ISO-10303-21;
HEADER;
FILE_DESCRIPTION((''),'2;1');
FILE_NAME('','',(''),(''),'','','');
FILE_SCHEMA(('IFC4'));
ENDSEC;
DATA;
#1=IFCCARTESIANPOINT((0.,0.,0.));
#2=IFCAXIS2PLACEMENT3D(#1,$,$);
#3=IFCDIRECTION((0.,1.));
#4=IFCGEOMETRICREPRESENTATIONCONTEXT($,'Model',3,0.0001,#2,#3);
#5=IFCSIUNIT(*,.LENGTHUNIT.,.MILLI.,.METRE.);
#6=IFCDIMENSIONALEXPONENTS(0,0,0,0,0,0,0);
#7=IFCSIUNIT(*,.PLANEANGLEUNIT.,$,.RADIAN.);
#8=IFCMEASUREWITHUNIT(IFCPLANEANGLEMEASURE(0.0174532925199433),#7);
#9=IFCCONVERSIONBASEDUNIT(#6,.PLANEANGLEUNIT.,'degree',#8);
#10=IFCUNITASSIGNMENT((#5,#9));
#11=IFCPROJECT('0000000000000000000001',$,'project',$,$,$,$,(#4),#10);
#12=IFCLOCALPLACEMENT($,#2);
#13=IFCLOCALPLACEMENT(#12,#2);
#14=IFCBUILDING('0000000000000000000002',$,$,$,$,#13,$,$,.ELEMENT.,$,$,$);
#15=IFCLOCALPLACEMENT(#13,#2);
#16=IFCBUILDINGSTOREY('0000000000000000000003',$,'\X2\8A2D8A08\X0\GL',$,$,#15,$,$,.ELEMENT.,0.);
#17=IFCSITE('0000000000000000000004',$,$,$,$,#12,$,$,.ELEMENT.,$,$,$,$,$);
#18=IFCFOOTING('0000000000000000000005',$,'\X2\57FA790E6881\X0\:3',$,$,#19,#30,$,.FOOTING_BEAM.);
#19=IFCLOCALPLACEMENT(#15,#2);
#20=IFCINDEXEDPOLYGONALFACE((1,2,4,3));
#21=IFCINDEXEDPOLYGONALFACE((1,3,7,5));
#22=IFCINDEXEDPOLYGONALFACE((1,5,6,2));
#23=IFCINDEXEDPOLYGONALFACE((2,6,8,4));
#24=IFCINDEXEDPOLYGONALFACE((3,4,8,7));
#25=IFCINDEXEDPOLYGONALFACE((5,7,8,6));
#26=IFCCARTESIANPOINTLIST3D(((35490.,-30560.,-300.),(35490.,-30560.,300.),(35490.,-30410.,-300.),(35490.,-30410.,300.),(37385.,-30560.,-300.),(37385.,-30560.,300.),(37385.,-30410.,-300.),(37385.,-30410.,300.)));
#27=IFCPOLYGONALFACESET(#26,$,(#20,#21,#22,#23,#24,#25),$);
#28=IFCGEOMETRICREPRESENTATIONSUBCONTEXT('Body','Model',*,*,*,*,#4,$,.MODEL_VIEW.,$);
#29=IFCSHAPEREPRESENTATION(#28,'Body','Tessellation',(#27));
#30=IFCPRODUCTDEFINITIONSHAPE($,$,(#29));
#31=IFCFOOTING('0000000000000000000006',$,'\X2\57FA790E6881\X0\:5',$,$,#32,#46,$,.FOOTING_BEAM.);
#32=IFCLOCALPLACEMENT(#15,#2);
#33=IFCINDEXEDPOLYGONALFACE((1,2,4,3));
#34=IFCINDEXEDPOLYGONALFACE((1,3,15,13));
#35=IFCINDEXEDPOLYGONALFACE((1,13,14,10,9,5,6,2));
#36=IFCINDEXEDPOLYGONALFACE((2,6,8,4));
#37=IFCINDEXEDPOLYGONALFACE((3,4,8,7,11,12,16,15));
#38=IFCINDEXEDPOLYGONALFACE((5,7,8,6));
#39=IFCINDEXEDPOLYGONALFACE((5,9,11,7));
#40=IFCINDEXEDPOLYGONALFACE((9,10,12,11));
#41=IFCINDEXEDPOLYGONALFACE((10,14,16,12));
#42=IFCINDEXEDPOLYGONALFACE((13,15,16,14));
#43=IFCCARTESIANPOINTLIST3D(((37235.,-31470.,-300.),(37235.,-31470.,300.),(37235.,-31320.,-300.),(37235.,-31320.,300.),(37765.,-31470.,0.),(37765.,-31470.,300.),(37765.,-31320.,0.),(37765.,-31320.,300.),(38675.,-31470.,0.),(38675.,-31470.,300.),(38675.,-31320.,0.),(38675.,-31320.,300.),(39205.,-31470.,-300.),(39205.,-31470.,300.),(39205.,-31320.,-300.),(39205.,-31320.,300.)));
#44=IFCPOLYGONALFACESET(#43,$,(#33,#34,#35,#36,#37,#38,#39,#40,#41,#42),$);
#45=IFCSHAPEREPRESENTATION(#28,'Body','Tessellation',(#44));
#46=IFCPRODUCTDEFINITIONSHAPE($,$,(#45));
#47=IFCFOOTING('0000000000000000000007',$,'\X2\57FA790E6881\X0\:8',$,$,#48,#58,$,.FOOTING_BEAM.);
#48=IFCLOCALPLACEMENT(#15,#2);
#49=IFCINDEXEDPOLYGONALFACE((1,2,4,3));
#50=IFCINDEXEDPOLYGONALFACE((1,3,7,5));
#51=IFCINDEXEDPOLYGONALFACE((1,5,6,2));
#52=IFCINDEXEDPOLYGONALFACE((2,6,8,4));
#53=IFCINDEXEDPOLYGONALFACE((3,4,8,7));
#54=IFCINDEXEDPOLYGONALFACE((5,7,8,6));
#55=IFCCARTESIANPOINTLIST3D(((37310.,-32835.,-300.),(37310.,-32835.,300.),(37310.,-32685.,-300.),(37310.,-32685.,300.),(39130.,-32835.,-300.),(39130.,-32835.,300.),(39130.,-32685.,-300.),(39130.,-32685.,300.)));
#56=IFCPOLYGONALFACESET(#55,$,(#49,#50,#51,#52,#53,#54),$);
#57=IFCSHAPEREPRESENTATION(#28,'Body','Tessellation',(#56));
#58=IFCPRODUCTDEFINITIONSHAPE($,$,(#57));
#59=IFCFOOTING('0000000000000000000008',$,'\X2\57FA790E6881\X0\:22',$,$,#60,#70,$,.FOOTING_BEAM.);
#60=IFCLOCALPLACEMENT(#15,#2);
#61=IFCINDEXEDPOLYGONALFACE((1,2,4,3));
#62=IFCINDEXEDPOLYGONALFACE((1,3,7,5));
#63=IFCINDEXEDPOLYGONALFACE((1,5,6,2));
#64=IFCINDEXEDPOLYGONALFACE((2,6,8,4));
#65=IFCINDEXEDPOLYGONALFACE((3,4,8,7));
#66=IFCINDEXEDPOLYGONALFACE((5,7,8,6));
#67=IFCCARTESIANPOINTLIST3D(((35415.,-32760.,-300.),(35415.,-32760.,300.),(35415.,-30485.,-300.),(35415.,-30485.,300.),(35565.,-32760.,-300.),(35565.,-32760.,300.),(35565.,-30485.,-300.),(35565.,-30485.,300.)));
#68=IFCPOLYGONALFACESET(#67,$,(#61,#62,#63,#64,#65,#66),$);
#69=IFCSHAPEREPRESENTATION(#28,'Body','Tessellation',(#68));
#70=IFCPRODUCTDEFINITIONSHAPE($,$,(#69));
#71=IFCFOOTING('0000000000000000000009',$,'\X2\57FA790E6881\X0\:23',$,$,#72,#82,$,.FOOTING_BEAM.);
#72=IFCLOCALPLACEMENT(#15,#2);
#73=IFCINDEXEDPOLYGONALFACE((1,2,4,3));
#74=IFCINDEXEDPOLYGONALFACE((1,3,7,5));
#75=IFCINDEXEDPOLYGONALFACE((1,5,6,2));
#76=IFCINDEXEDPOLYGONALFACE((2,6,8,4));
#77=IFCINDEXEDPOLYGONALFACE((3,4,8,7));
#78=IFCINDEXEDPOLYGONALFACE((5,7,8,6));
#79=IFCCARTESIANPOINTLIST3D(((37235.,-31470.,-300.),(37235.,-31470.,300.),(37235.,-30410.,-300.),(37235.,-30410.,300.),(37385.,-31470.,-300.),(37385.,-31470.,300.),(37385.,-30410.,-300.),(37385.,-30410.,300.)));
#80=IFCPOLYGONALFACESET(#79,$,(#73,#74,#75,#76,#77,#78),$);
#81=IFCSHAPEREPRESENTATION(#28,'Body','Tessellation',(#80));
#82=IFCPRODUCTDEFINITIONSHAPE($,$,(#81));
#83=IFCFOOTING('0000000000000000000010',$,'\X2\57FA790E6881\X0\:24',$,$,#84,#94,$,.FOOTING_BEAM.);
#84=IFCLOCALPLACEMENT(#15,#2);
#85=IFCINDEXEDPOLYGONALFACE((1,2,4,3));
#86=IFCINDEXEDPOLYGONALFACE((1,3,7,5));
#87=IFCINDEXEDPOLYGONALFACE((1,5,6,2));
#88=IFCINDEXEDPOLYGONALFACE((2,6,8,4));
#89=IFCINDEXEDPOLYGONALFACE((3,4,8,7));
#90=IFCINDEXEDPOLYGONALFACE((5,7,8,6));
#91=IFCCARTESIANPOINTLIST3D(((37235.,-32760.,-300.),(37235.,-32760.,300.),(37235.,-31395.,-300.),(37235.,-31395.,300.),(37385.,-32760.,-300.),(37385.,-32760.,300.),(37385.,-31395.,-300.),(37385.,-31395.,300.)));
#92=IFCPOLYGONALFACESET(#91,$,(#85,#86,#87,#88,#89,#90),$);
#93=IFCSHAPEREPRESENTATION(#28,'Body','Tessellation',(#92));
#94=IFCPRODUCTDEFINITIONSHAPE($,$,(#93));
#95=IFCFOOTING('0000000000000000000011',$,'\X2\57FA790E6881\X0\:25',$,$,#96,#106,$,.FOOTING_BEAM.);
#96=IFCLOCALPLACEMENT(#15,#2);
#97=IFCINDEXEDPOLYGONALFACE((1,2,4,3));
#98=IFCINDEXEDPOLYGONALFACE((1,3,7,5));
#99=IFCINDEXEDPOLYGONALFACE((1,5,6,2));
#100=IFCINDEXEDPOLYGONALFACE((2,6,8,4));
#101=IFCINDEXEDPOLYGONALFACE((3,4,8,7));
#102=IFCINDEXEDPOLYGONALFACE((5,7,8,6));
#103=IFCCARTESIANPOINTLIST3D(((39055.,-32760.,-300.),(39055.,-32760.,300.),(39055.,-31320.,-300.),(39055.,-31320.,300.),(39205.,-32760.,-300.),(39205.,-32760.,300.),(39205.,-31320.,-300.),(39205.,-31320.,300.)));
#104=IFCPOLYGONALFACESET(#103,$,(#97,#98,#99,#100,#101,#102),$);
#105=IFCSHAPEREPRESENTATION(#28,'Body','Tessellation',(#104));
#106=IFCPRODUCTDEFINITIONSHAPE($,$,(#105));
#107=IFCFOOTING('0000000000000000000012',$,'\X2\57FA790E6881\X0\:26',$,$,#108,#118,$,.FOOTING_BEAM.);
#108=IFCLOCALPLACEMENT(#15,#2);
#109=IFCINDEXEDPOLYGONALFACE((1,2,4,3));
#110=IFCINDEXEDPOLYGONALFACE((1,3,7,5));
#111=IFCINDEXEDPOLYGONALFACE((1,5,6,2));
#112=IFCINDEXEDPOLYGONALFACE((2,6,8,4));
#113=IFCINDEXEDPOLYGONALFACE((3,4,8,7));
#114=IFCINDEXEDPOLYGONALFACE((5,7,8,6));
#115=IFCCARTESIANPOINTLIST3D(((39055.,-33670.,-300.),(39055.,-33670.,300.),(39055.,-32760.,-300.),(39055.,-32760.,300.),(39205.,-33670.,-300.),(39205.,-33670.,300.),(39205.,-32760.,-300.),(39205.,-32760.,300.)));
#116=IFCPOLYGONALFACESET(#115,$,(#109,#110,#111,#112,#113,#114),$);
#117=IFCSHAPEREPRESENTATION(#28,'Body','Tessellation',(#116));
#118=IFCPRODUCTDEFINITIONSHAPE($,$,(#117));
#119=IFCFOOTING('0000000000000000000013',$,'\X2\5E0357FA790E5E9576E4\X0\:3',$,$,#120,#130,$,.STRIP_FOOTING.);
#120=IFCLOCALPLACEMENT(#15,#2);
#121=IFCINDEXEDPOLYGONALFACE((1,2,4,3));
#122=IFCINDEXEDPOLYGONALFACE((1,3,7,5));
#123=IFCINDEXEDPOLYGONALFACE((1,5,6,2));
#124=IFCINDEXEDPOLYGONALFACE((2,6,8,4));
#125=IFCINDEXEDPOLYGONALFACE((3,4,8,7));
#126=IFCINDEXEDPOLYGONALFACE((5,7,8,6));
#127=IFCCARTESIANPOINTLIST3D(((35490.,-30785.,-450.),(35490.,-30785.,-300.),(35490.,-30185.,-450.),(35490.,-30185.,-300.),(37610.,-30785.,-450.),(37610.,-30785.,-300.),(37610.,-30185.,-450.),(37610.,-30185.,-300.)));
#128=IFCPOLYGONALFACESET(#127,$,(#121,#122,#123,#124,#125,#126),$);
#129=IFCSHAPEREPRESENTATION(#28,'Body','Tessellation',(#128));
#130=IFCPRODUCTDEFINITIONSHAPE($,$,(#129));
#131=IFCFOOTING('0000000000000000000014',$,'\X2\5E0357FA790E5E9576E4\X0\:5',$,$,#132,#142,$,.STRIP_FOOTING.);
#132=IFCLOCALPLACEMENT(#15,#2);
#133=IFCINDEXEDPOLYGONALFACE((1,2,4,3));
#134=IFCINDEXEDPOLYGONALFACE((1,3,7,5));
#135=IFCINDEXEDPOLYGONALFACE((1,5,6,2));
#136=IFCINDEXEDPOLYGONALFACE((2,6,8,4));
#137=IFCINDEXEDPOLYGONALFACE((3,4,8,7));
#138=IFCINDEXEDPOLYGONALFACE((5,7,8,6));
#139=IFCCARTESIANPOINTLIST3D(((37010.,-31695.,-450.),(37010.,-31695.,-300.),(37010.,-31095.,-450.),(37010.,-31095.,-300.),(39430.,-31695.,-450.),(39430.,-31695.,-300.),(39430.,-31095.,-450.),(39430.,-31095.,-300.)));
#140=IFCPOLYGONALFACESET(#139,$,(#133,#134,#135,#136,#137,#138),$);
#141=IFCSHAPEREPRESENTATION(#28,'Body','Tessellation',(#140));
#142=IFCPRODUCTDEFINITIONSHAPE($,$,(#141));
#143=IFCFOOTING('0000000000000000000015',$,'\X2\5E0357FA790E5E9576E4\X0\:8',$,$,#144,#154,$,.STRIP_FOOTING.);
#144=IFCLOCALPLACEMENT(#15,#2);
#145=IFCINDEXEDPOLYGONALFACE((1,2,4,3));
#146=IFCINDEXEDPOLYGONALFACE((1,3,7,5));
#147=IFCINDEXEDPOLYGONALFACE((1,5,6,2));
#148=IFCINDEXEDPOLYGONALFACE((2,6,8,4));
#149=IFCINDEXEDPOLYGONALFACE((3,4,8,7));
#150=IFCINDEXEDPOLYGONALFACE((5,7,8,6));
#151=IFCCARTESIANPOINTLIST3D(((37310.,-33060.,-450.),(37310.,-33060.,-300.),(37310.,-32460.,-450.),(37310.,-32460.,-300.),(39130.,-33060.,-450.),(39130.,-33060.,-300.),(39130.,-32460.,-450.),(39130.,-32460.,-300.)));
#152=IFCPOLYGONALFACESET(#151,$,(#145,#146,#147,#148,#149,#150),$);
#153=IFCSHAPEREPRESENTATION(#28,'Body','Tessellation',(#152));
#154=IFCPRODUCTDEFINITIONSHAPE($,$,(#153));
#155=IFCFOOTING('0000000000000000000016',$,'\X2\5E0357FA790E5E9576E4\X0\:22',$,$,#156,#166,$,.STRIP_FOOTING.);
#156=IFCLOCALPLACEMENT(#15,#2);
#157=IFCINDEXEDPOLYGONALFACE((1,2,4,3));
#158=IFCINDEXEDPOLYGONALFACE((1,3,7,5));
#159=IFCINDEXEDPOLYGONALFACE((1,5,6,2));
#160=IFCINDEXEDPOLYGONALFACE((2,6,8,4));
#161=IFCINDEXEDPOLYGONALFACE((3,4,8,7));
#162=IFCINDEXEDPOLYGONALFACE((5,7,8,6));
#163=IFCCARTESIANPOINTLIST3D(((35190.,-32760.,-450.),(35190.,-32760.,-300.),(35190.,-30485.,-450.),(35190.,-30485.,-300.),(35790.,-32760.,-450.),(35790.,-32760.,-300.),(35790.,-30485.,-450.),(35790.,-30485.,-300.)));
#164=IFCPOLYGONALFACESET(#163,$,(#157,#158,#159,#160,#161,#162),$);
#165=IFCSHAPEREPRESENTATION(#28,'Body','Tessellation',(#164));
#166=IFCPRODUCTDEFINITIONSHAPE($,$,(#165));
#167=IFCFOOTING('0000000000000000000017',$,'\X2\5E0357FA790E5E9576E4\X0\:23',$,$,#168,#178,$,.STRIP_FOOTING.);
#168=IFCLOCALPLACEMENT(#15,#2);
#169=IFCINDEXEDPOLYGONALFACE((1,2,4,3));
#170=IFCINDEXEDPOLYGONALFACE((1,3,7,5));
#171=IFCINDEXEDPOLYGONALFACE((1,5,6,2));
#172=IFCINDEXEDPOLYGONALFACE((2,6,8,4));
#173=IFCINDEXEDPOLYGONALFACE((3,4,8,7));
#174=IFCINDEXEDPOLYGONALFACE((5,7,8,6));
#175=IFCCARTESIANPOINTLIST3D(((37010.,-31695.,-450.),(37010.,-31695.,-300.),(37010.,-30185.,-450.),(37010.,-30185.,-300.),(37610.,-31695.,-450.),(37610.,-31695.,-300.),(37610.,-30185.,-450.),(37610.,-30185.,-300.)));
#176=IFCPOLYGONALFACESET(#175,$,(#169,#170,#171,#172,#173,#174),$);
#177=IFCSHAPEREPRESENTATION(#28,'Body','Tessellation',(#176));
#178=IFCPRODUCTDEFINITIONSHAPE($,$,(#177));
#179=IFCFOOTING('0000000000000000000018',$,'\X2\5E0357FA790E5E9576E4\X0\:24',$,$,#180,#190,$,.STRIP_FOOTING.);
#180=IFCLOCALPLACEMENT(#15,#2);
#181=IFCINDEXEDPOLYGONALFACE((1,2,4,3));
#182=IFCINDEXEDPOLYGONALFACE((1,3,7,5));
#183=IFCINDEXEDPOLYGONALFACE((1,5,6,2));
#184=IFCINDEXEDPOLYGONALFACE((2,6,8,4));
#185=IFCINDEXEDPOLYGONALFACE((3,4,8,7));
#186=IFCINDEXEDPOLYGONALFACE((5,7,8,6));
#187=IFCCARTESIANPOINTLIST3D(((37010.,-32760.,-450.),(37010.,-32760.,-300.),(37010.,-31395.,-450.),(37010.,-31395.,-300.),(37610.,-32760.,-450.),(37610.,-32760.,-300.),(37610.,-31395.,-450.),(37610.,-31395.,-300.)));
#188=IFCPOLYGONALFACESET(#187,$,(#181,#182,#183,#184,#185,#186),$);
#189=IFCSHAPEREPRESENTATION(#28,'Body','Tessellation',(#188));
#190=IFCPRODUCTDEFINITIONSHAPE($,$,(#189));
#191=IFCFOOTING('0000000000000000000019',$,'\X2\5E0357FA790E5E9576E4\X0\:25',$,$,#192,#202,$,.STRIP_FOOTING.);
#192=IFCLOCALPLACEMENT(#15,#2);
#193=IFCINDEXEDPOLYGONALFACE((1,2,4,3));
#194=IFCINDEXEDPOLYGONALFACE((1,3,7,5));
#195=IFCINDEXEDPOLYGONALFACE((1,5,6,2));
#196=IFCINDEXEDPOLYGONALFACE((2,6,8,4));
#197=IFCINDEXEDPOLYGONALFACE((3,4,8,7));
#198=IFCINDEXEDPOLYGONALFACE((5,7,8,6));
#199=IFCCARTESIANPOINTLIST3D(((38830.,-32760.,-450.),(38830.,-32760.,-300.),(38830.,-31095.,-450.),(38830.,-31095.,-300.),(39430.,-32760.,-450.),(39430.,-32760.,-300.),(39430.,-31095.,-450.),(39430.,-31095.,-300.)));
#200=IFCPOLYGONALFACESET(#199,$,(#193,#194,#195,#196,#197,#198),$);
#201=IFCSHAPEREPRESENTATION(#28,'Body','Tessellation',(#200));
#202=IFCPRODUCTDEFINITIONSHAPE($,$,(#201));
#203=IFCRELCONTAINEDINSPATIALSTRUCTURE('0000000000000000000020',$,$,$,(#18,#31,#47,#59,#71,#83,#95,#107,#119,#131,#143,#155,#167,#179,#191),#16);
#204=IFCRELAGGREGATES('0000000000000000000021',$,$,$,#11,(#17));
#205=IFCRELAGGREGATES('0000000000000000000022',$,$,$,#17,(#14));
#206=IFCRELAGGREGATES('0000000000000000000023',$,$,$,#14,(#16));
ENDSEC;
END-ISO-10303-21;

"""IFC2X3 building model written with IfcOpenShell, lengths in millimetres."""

from ifc_helpers import new_model, entity, si_unit, converted_unit, direction, frame, origin, origin_with_axes, origin_2d, place, context, subcontext, project, spatial, rectangle, extrude, boolean, element, save


model = new_model("IFC2X3")

# Units and contexts
model_context = context("Model", 3, precision=0.0001, world=origin(), true_north=direction((0.0, 1.0)))
body_context = subcontext(model_context, "Body", "Model", "MODEL_VIEW")
ifc_project = project(units=[si_unit("LENGTHUNIT", "METRE", prefix="MILLI"), converted_unit("PLANEANGLEUNIT", "degree", entity("IfcPlaneAngleMeasure", 0.0174532925199433), si_unit("PLANEANGLEUNIT", "RADIAN"), dimensions=[0, 0, 0, 0, 0, 0, 0])], contexts=[model_context])

# Site, building, storey
site_placement = place(None, origin())
site = spatial("IfcSite", under=ifc_project, at=site_placement, CompositionType="ELEMENT")
building_placement = place(site_placement, origin())
building = spatial("IfcBuilding", under=site, at=building_placement, CompositionType="ELEMENT")
storey_placement = place(building_placement, origin())
storey = spatial("IfcBuildingStorey", under=building, at=storey_placement, Name="設計GL", CompositionType="ELEMENT", Elevation=0.0)

# Footings
footing_1_placement = place(storey_placement, frame((35490.0, -30485.0, 0.0), z_axis=(1.0, 0.0, 0.0), x_axis=(0.0, 1.0, 0.0)))
element("IfcFooting", 1, at=footing_1_placement, inside=storey, Name="基礎梁:3", PredefinedType="FOOTING_BEAM", context=body_context, shape_type="SolidModel", body=[
    extrude(rectangle(XDim=150.0, YDim=600.0, at=origin_2d()), origin_with_axes(), (0.0, 0.0, 1.0), 1895.0),
])
footing_2_placement = place(storey_placement, frame((37235.0, -31395.0, 0.0), z_axis=(1.0, 0.0, 0.0), x_axis=(0.0, 1.0, 0.0)))
element("IfcFooting", 2, at=footing_2_placement, inside=storey, Name="基礎梁:5", PredefinedType="FOOTING_BEAM", context=body_context, shape_type="CSG", body=[
    boolean("DIFFERENCE", extrude(rectangle(XDim=150.0, YDim=600.0, at=origin_2d()), origin_with_axes(), (0.0, 0.0, 1.0), 1970.0), extrude(rectangle(XDim=154.0, YDim=300.0, at=origin_2d()), frame((0.0, 150.0, 530.0), z_axis=(0.0, 0.0, 1.0), x_axis=(1.0, 0.0, 0.0)), (0.0, 0.0, 1.0), 910.0)),
])
footing_3_placement = place(storey_placement, frame((37310.0, -32760.0, 0.0), z_axis=(1.0, 0.0, 0.0), x_axis=(0.0, 1.0, 0.0)))
element("IfcFooting", 3, at=footing_3_placement, inside=storey, Name="基礎梁:8", PredefinedType="FOOTING_BEAM", context=body_context, shape_type="SolidModel", body=[
    extrude(rectangle(XDim=150.0, YDim=600.0, at=origin_2d()), origin_with_axes(), (0.0, 0.0, 1.0), 1820.0),
])
footing_4_placement = place(storey_placement, frame((35490.0, -30485.0, 0.0), z_axis=(0.0, -1.0, 0.0), x_axis=(1.0, 0.0, 0.0)))
element("IfcFooting", 4, at=footing_4_placement, inside=storey, Name="基礎梁:22", PredefinedType="FOOTING_BEAM", context=body_context, shape_type="SolidModel", body=[
    extrude(rectangle(XDim=150.0, YDim=600.0, at=origin_2d()), origin_with_axes(), (0.0, 0.0, 1.0), 2275.0),
])
footing_5_placement = place(storey_placement, frame((37310.0, -30410.0, 0.0), z_axis=(0.0, -1.0, 0.0), x_axis=(1.0, 0.0, 0.0)))
element("IfcFooting", 5, at=footing_5_placement, inside=storey, Name="基礎梁:23", PredefinedType="FOOTING_BEAM", context=body_context, shape_type="SolidModel", body=[
    extrude(rectangle(XDim=150.0, YDim=600.0, at=origin_2d()), origin_with_axes(), (0.0, 0.0, 1.0), 1060.0),
])
footing_6_placement = place(storey_placement, frame((37310.0, -31395.0, 0.0), z_axis=(0.0, -1.0, 0.0), x_axis=(1.0, 0.0, 0.0)))
element("IfcFooting", 6, at=footing_6_placement, inside=storey, Name="基礎梁:24", PredefinedType="FOOTING_BEAM", context=body_context, shape_type="SolidModel", body=[
    extrude(rectangle(XDim=150.0, YDim=600.0, at=origin_2d()), origin_with_axes(), (0.0, 0.0, 1.0), 1365.0),
])
footing_7_placement = place(storey_placement, frame((39130.0, -31320.0, 0.0), z_axis=(0.0, -1.0, 0.0), x_axis=(1.0, 0.0, 0.0)))
element("IfcFooting", 7, at=footing_7_placement, inside=storey, Name="基礎梁:25", PredefinedType="FOOTING_BEAM", context=body_context, shape_type="SolidModel", body=[
    extrude(rectangle(XDim=150.0, YDim=600.0, at=origin_2d()), origin_with_axes(), (0.0, 0.0, 1.0), 1440.0),
])
footing_8_placement = place(storey_placement, frame((39130.0, -32760.0, 0.0), z_axis=(0.0, -1.0, 0.0), x_axis=(1.0, 0.0, 0.0)))
element("IfcFooting", 8, at=footing_8_placement, inside=storey, Name="基礎梁:26", PredefinedType="FOOTING_BEAM", context=body_context, shape_type="SolidModel", body=[
    extrude(rectangle(XDim=150.0, YDim=600.0, at=origin_2d()), origin_with_axes(), (0.0, 0.0, 1.0), 910.0),
])
footing_9_placement = place(storey_placement, frame((35490.0, -30485.0, -375.0), z_axis=(1.0, 0.0, 0.0), x_axis=(0.0, -1.0, 0.0)))
element("IfcFooting", 9, at=footing_9_placement, inside=storey, Name="布基礎底盤:3", PredefinedType="STRIP_FOOTING", context=body_context, shape_type="SweptSolid", body=[
    extrude(rectangle(XDim=600.0, YDim=150.0, at=origin_2d()), origin_with_axes(), (0.0, 0.0, 1.0), 2120.0),
])
footing_10_placement = place(storey_placement, frame((37010.0, -31395.0, -375.0), z_axis=(1.0, 0.0, 0.0), x_axis=(0.0, -1.0, 0.0)))
element("IfcFooting", 10, at=footing_10_placement, inside=storey, Name="布基礎底盤:5", PredefinedType="STRIP_FOOTING", context=body_context, shape_type="SweptSolid", body=[
    extrude(rectangle(XDim=600.0, YDim=150.0, at=origin_2d()), origin_with_axes(), (0.0, 0.0, 1.0), 2420.0),
])
footing_11_placement = place(storey_placement, frame((37310.0, -32760.0, -375.0), z_axis=(1.0, 0.0, 0.0), x_axis=(0.0, -1.0, 0.0)))
element("IfcFooting", 11, at=footing_11_placement, inside=storey, Name="布基礎底盤:8", PredefinedType="STRIP_FOOTING", context=body_context, shape_type="SweptSolid", body=[
    extrude(rectangle(XDim=600.0, YDim=150.0, at=origin_2d()), origin_with_axes(), (0.0, 0.0, 1.0), 1820.0),
])
footing_12_placement = place(storey_placement, frame((35490.0, -30485.0, -375.0), z_axis=(0.0, -1.0, 0.0), x_axis=(-1.0, 0.0, 0.0)))
element("IfcFooting", 12, at=footing_12_placement, inside=storey, Name="布基礎底盤:22", PredefinedType="STRIP_FOOTING", context=body_context, shape_type="SweptSolid", body=[
    extrude(rectangle(XDim=600.0, YDim=150.0, at=origin_2d()), origin_with_axes(), (0.0, 0.0, 1.0), 2275.0),
])
footing_13_placement = place(storey_placement, frame((37310.0, -30185.0, -375.0), z_axis=(0.0, -1.0, 0.0), x_axis=(-1.0, 0.0, 0.0)))
element("IfcFooting", 13, at=footing_13_placement, inside=storey, Name="布基礎底盤:23", PredefinedType="STRIP_FOOTING", context=body_context, shape_type="SweptSolid", body=[
    extrude(rectangle(XDim=600.0, YDim=150.0, at=origin_2d()), origin_with_axes(), (0.0, 0.0, 1.0), 1510.0),
])
footing_14_placement = place(storey_placement, frame((37310.0, -31395.0, -375.0), z_axis=(0.0, -1.0, 0.0), x_axis=(-1.0, 0.0, 0.0)))
element("IfcFooting", 14, at=footing_14_placement, inside=storey, Name="布基礎底盤:24", PredefinedType="STRIP_FOOTING", context=body_context, shape_type="SweptSolid", body=[
    extrude(rectangle(XDim=600.0, YDim=150.0, at=origin_2d()), origin_with_axes(), (0.0, 0.0, 1.0), 1365.0),
])
footing_15_placement = place(storey_placement, frame((39130.0, -31095.0, -375.0), z_axis=(0.0, -1.0, 0.0), x_axis=(-1.0, 0.0, 0.0)))
element("IfcFooting", 15, at=footing_15_placement, inside=storey, Name="布基礎底盤:25", PredefinedType="STRIP_FOOTING", context=body_context, shape_type="SweptSolid", body=[
    extrude(rectangle(XDim=600.0, YDim=150.0, at=origin_2d()), origin_with_axes(), (0.0, 0.0, 1.0), 1665.0),
])

save(model, "model.ifc")
